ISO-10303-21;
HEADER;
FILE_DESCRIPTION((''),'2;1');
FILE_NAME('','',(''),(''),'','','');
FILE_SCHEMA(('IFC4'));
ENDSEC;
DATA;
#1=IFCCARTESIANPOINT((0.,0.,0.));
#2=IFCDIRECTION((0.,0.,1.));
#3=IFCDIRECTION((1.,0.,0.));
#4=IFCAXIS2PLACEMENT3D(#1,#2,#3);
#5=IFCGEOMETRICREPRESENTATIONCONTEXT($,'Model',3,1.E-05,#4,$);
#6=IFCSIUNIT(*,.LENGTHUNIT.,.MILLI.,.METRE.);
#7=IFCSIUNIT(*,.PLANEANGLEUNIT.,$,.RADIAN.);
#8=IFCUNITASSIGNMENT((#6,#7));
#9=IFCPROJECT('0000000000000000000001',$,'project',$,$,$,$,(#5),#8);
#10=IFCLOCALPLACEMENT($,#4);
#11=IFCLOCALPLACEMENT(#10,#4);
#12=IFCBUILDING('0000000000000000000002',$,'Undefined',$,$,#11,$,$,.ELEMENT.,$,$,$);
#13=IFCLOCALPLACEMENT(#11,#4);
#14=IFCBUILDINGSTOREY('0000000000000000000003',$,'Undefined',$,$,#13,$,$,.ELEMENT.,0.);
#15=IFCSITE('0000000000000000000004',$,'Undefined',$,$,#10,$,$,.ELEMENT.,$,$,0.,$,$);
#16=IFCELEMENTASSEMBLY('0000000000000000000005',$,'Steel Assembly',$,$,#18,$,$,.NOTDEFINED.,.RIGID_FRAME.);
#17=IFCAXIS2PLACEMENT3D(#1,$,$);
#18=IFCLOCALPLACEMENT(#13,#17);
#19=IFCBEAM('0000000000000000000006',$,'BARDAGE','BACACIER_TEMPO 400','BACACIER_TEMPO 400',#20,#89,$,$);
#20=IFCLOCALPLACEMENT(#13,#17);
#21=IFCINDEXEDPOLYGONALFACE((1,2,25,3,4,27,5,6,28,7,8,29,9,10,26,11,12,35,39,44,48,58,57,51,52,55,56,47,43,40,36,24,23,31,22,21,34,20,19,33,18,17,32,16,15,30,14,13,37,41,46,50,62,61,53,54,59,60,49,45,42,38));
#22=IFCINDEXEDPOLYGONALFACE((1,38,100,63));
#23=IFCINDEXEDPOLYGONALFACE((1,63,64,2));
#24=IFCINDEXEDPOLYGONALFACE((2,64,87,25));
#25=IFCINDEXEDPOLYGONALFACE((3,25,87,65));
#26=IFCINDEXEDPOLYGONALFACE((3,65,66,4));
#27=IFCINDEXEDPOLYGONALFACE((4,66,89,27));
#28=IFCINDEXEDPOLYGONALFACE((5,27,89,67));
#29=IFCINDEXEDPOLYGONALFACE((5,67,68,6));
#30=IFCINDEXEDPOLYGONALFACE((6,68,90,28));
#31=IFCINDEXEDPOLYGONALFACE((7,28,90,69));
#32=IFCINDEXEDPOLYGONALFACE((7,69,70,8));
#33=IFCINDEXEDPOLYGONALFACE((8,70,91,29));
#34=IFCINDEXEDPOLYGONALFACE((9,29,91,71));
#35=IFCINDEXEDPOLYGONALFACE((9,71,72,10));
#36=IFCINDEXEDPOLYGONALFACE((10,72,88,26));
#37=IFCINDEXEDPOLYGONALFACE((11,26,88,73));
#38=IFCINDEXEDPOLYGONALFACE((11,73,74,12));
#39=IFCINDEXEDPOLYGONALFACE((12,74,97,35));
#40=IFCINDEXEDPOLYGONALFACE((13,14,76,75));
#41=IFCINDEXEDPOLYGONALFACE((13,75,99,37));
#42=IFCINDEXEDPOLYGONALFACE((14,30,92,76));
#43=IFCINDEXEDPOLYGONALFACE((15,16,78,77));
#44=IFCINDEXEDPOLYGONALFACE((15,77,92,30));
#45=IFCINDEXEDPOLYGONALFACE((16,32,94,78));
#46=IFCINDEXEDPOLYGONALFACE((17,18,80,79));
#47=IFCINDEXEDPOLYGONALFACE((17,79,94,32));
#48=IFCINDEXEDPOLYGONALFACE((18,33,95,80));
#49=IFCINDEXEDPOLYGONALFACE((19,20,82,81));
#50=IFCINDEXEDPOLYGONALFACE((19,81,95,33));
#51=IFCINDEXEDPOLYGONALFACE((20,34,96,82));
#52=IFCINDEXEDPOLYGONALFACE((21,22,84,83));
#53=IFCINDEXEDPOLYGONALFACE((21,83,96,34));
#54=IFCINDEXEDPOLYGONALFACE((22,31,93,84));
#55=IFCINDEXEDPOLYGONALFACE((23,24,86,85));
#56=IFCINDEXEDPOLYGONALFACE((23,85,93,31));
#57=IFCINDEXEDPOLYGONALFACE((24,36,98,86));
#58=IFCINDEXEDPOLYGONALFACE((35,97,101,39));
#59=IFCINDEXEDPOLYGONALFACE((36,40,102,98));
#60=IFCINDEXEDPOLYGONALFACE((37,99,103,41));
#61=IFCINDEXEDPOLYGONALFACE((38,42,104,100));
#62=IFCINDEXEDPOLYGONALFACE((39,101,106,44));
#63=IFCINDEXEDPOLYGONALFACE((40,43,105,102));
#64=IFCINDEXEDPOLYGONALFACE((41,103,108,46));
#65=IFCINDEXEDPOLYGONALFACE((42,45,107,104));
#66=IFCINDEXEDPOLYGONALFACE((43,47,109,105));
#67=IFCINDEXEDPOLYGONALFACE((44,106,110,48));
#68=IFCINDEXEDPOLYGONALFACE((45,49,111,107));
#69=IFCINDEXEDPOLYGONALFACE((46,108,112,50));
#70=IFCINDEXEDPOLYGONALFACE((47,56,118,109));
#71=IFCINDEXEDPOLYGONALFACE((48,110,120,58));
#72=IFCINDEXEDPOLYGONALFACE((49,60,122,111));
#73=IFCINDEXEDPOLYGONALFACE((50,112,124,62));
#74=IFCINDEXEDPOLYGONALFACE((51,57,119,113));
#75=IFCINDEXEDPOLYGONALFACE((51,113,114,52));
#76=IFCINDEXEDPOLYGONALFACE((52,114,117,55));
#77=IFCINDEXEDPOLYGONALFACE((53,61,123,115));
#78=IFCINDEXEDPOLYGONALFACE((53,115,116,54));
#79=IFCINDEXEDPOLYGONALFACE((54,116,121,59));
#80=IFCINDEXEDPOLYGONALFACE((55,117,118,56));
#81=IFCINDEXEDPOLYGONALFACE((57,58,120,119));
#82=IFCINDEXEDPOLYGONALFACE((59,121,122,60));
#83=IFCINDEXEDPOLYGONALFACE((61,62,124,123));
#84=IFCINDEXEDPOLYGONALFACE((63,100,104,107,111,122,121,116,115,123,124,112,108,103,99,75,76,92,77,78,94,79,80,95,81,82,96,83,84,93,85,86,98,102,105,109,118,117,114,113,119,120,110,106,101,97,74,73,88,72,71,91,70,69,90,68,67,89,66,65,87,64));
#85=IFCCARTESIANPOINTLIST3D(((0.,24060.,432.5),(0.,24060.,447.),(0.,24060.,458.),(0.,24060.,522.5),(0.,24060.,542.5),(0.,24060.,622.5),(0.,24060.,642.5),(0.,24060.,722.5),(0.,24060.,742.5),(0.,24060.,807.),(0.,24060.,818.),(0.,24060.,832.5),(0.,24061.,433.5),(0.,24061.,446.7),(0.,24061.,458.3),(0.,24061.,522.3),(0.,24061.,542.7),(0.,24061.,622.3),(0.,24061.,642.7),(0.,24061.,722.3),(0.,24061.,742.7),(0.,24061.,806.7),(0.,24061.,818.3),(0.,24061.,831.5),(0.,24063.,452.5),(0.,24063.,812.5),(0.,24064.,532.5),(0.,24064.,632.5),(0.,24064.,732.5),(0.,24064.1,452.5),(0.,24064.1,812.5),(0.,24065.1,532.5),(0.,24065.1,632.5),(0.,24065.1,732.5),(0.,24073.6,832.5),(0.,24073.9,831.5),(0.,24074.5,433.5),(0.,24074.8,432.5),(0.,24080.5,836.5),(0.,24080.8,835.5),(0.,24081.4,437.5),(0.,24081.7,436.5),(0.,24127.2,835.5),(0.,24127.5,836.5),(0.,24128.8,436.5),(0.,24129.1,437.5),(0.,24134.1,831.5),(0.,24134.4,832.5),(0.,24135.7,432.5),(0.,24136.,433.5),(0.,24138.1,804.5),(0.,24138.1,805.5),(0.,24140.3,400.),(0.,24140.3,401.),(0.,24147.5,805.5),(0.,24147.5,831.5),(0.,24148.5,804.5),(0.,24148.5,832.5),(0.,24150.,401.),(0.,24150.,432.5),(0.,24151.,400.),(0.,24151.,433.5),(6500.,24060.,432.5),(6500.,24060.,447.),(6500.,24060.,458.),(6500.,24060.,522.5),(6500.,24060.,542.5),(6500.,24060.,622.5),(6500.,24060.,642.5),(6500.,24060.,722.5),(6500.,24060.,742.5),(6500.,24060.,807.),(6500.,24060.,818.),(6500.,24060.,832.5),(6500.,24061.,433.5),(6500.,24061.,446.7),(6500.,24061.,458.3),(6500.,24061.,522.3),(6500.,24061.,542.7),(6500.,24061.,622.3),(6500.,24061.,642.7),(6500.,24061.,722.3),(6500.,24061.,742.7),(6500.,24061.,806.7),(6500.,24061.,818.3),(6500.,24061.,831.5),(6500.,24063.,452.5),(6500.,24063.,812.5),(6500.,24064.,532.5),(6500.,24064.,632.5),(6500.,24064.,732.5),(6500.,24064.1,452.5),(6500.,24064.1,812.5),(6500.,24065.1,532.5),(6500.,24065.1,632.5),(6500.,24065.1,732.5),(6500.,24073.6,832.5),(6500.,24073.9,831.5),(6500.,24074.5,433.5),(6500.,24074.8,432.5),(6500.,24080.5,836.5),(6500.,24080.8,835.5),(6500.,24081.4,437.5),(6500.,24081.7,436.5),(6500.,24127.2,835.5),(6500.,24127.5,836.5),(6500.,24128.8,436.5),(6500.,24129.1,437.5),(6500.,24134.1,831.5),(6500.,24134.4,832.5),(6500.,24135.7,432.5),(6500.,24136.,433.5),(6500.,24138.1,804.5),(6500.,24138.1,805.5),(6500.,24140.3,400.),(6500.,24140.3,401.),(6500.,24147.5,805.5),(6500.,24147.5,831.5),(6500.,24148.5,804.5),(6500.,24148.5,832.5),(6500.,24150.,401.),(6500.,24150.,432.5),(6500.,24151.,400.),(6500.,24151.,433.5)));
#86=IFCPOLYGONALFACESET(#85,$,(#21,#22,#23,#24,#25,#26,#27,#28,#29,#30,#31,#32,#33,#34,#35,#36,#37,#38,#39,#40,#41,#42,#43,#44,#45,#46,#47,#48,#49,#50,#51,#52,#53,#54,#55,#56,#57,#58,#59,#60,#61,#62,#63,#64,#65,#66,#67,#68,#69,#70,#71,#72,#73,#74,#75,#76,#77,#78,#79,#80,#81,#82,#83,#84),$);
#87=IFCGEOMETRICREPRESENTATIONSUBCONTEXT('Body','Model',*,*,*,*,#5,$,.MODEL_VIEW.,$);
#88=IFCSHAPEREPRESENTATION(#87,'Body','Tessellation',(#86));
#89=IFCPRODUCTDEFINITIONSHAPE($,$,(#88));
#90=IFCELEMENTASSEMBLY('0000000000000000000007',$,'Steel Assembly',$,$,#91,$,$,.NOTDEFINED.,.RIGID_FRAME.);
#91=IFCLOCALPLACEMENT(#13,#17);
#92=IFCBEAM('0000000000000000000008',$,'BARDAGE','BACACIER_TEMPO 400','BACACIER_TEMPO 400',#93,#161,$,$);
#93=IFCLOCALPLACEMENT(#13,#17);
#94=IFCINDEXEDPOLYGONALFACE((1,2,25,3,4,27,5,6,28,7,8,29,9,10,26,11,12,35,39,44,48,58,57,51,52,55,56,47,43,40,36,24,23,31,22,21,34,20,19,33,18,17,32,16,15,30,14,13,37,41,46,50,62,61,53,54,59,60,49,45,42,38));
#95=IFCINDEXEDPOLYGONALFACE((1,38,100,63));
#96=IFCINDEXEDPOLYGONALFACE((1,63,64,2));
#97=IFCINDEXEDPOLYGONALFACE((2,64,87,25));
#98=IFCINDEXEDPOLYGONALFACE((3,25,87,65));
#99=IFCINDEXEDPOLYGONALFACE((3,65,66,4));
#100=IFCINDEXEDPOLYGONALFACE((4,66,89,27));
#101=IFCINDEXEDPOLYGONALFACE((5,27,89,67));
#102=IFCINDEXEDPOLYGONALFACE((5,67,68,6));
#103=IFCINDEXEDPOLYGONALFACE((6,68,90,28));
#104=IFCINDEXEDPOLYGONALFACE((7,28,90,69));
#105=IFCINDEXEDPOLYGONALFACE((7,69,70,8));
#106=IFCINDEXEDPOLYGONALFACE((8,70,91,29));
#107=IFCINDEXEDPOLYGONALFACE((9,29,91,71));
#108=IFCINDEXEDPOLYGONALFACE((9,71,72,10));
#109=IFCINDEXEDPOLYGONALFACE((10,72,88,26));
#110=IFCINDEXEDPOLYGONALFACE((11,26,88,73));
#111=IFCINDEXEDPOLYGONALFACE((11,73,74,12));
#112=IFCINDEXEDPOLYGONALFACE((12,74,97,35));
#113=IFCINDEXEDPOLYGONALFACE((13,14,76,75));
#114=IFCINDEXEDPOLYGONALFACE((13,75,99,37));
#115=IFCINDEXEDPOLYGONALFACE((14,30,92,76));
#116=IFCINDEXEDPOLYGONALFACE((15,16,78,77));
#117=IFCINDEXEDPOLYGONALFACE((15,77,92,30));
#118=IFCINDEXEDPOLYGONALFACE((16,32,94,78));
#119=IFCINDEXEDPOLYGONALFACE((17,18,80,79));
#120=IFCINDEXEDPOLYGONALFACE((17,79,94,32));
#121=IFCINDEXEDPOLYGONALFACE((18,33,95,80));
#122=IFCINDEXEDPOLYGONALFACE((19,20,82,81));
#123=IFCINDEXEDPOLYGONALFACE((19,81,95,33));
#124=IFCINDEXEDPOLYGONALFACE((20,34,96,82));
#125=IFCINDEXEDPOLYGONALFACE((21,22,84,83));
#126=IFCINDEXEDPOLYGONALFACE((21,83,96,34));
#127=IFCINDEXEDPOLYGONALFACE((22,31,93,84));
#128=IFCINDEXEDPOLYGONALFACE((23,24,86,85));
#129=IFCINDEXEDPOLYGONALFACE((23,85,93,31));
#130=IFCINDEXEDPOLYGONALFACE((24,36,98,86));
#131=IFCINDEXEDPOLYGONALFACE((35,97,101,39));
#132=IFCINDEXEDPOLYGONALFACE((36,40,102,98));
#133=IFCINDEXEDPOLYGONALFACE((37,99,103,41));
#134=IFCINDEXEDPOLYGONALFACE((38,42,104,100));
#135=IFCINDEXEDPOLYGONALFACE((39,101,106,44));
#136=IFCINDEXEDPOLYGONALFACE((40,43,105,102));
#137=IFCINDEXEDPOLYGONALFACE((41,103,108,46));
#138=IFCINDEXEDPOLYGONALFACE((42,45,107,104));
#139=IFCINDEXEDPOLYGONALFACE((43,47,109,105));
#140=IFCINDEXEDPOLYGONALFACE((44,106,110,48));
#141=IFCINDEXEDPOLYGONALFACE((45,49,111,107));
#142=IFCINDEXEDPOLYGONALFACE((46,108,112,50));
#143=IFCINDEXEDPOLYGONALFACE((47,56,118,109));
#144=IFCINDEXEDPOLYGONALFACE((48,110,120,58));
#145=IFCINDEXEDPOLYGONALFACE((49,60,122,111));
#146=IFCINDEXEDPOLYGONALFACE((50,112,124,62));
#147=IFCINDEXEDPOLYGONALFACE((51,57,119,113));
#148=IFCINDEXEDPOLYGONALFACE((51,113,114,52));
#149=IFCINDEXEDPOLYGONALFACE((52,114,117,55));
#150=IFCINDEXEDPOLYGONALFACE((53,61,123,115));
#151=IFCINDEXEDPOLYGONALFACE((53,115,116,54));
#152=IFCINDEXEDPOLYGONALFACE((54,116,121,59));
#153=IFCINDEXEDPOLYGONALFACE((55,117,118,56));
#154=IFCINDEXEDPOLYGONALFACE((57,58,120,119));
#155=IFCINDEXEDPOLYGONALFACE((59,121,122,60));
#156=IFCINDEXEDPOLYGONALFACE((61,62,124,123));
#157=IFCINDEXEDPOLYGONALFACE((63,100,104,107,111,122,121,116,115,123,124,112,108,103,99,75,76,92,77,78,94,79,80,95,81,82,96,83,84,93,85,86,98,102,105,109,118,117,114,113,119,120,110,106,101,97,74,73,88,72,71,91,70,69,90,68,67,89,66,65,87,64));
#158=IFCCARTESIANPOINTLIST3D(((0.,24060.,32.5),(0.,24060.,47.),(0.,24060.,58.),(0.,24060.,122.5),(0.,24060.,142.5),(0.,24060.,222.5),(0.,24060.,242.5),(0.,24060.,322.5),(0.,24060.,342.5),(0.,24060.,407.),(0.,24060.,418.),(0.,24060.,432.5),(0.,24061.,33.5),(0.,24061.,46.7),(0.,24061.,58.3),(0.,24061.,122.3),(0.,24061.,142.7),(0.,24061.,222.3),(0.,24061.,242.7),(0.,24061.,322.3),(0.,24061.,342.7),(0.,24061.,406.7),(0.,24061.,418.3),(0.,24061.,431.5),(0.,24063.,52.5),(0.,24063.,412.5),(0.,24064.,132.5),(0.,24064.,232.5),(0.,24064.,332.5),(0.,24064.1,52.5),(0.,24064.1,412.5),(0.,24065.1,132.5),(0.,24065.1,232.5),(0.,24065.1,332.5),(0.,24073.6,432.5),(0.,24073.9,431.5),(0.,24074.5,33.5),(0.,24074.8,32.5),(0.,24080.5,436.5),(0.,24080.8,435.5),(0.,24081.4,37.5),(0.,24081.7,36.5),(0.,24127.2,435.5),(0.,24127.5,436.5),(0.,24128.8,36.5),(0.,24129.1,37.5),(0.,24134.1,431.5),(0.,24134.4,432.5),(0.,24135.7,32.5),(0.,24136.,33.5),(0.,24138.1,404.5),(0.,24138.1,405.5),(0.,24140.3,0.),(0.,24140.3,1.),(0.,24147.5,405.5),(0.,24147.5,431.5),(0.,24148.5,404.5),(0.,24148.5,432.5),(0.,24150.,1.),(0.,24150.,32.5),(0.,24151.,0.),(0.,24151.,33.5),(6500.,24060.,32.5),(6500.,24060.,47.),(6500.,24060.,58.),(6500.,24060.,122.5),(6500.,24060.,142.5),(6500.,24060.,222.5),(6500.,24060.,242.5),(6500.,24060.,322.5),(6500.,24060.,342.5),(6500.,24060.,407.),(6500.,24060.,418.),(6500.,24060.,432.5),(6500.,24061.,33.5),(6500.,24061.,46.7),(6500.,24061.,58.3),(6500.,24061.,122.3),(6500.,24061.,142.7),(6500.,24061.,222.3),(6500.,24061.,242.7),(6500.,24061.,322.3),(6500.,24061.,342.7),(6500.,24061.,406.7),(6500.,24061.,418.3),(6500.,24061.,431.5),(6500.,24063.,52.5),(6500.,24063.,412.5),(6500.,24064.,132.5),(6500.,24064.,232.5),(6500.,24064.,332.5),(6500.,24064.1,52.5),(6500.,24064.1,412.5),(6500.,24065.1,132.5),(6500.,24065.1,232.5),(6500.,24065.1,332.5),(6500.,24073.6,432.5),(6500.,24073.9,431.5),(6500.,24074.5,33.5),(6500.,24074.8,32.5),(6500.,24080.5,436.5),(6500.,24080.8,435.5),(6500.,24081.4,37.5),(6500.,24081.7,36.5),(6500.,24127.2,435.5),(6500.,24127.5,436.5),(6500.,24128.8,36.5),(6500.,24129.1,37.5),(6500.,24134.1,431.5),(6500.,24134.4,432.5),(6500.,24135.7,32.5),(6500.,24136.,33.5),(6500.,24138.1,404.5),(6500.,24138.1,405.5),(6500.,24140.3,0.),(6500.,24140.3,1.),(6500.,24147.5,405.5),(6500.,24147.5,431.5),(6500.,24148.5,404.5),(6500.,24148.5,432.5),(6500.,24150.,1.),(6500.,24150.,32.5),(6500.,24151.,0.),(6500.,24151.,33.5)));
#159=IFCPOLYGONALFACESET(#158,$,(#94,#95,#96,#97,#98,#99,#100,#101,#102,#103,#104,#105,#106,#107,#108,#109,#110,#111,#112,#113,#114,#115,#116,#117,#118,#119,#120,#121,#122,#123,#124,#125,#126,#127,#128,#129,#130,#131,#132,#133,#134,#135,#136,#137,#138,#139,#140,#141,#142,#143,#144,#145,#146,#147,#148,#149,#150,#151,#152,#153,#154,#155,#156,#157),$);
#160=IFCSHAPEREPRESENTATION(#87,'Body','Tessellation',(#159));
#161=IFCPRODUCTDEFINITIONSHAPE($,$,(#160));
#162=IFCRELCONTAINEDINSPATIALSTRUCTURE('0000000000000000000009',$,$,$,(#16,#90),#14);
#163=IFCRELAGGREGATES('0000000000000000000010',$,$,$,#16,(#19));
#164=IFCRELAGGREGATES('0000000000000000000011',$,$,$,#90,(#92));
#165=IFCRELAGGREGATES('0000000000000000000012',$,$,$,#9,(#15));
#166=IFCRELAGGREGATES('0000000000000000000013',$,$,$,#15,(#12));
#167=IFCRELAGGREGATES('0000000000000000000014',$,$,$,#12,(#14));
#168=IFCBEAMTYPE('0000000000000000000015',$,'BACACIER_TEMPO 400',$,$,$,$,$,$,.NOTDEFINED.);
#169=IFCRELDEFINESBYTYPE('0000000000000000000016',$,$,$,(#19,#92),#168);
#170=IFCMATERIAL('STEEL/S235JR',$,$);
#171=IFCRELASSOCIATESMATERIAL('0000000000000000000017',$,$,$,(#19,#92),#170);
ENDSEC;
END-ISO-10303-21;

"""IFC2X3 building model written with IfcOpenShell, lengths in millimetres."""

from ifc_helpers import new_model, si_unit, frame, origin_with_axes, place, context, subcontext, project, spatial, polyline, outline, extrude, material, type_object, element, aggregate, save


model = new_model("IFC2X3")

# Units and contexts
model_context = context("Model", 3, precision=1e-05, world=origin_with_axes())
body_context = subcontext(model_context, "Body", "Model", "MODEL_VIEW")
ifc_project = project(units=[si_unit("LENGTHUNIT", "METRE", prefix="MILLI"), si_unit("PLANEANGLEUNIT", "RADIAN")], contexts=[model_context])

# Site, building, storey
site_placement = place(None, origin_with_axes())
site = spatial("IfcSite", under=ifc_project, at=site_placement, Name="Undefined", CompositionType="ELEMENT", RefElevation=0.0)
building_placement = place(site_placement, origin_with_axes())
building = spatial("IfcBuilding", under=site, at=building_placement, Name="Undefined", CompositionType="ELEMENT")
storey_placement = place(building_placement, origin_with_axes())
storey = spatial("IfcBuildingStorey", under=building, at=storey_placement, Name="Undefined", CompositionType="ELEMENT", Elevation=0.0)

# Element assemblies, beams
ifc_material_1 = material(Name="STEEL/S235JR")
beam_type_1 = type_object("IfcBeamType", Name="BACACIER_TEMPO 400", PredefinedType="NOTDEFINED")
assembly_1_placement = place(storey_placement, origin_with_axes())
assembly_1 = element("IfcElementAssembly", 1, at=assembly_1_placement, inside=storey, Name="Steel Assembly", AssemblyPlace="NOTDEFINED", PredefinedType="RIGID_FRAME")
beam_1_placement = place(assembly_1_placement, frame((0.0, 24105.5, 618.2), z_axis=(0.0, 1.0, 0.0), x_axis=(1.0, 0.0, 0.0)))
beam_1 = element("IfcBeam", 2, at=beam_1_placement, type_object=beam_type_1, material=ifc_material_1, Name="BARDAGE", Description="BACACIER_TEMPO 400", ObjectType="BACACIER_TEMPO 400", context=body_context, shape_type="SweptSolid", body=[
    extrude(outline(polyline([(218.2, -25.0), (214.2, -31.9), (214.2, -45.5), (199.8, -45.5), (194.2, -42.5), (188.8, -45.5), (124.2, -45.5), (114.2, -41.5), (104.2, -45.5), (24.2, -45.5), (14.2, -41.5), (4.2, -45.5), (-75.8, -45.5), (-85.8, -41.5), (-95.8, -45.5), (-160.2, -45.5), (-165.8, -42.5), (-171.2, -45.5), (-185.8, -45.5), (-185.8, -30.7), (-181.8, -23.8), (-181.8, 23.3), (-185.8, 30.2), (-185.8, 44.5), (-217.2, 44.5), (-217.2, 34.8), (-218.2, 34.8), (-218.2, 45.5), (-184.8, 45.5), (-184.8, 30.5), (-180.8, 23.6), (-180.8, -24.1), (-184.8, -31.0), (-184.8, -44.5), (-171.5, -44.5), (-165.8, -41.4), (-160.0, -44.5), (-95.9, -44.5), (-85.8, -40.4), (-75.6, -44.5), (4.1, -44.5), (14.2, -40.4), (24.4, -44.5), (104.1, -44.5), (114.2, -40.4), (124.4, -44.5), (188.5, -44.5), (194.2, -41.4), (200.0, -44.5), (213.2, -44.5), (213.2, -31.6), (217.2, -24.7), (217.2, 21.7), (213.2, 28.6), (213.2, 42.0), (187.2, 42.0), (187.2, 32.5), (186.2, 32.5), (186.2, 43.0), (214.2, 43.0), (214.2, 28.9), (218.2, 22.0), (218.2, -25.0)])), frame((6500.0, 0.0, 0.0), z_axis=(-1.0, 0.0, 0.0), x_axis=(0.0, -1.0, 0.0)), (0.0, 0.0, 1.0), 6500.0),
])
aggregate(assembly_1, [beam_1])
assembly_2_placement = place(storey_placement, origin_with_axes())
assembly_2 = element("IfcElementAssembly", 3, at=assembly_2_placement, inside=storey, Name="Steel Assembly", AssemblyPlace="NOTDEFINED", PredefinedType="RIGID_FRAME")
beam_2_placement = place(assembly_2_placement, frame((0.0, 24105.5, 218.2), z_axis=(0.0, 1.0, 0.0), x_axis=(1.0, 0.0, 0.0)))
beam_2 = element("IfcBeam", 4, at=beam_2_placement, type_object=beam_type_1, material=ifc_material_1, Name="BARDAGE", Description="BACACIER_TEMPO 400", ObjectType="BACACIER_TEMPO 400", context=body_context, shape_type="SweptSolid", body=[
    extrude(outline(polyline([(218.2, -25.0), (214.2, -31.9), (214.2, -45.5), (199.8, -45.5), (194.2, -42.5), (188.8, -45.5), (124.2, -45.5), (114.2, -41.5), (104.2, -45.5), (24.2, -45.5), (14.2, -41.5), (4.2, -45.5), (-75.8, -45.5), (-85.8, -41.5), (-95.8, -45.5), (-160.2, -45.5), (-165.8, -42.5), (-171.2, -45.5), (-185.8, -45.5), (-185.8, -30.7), (-181.8, -23.8), (-181.8, 23.3), (-185.8, 30.2), (-185.8, 44.5), (-217.2, 44.5), (-217.2, 34.8), (-218.2, 34.8), (-218.2, 45.5), (-184.8, 45.5), (-184.8, 30.5), (-180.8, 23.6), (-180.8, -24.1), (-184.8, -31.0), (-184.8, -44.5), (-171.5, -44.5), (-165.8, -41.4), (-160.0, -44.5), (-95.9, -44.5), (-85.8, -40.4), (-75.6, -44.5), (4.1, -44.5), (14.2, -40.4), (24.4, -44.5), (104.1, -44.5), (114.2, -40.4), (124.4, -44.5), (188.5, -44.5), (194.2, -41.4), (200.0, -44.5), (213.2, -44.5), (213.2, -31.6), (217.2, -24.7), (217.2, 21.7), (213.2, 28.6), (213.2, 42.0), (187.2, 42.0), (187.2, 32.5), (186.2, 32.5), (186.2, 43.0), (214.2, 43.0), (214.2, 28.9), (218.2, 22.0), (218.2, -25.0)])), frame((6500.0, 0.0, 0.0), z_axis=(-1.0, 0.0, 0.0), x_axis=(0.0, -1.0, 0.0)), (0.0, 0.0, 1.0), 6500.0),
])
aggregate(assembly_2, [beam_2])

save(model, "model.ifc")
